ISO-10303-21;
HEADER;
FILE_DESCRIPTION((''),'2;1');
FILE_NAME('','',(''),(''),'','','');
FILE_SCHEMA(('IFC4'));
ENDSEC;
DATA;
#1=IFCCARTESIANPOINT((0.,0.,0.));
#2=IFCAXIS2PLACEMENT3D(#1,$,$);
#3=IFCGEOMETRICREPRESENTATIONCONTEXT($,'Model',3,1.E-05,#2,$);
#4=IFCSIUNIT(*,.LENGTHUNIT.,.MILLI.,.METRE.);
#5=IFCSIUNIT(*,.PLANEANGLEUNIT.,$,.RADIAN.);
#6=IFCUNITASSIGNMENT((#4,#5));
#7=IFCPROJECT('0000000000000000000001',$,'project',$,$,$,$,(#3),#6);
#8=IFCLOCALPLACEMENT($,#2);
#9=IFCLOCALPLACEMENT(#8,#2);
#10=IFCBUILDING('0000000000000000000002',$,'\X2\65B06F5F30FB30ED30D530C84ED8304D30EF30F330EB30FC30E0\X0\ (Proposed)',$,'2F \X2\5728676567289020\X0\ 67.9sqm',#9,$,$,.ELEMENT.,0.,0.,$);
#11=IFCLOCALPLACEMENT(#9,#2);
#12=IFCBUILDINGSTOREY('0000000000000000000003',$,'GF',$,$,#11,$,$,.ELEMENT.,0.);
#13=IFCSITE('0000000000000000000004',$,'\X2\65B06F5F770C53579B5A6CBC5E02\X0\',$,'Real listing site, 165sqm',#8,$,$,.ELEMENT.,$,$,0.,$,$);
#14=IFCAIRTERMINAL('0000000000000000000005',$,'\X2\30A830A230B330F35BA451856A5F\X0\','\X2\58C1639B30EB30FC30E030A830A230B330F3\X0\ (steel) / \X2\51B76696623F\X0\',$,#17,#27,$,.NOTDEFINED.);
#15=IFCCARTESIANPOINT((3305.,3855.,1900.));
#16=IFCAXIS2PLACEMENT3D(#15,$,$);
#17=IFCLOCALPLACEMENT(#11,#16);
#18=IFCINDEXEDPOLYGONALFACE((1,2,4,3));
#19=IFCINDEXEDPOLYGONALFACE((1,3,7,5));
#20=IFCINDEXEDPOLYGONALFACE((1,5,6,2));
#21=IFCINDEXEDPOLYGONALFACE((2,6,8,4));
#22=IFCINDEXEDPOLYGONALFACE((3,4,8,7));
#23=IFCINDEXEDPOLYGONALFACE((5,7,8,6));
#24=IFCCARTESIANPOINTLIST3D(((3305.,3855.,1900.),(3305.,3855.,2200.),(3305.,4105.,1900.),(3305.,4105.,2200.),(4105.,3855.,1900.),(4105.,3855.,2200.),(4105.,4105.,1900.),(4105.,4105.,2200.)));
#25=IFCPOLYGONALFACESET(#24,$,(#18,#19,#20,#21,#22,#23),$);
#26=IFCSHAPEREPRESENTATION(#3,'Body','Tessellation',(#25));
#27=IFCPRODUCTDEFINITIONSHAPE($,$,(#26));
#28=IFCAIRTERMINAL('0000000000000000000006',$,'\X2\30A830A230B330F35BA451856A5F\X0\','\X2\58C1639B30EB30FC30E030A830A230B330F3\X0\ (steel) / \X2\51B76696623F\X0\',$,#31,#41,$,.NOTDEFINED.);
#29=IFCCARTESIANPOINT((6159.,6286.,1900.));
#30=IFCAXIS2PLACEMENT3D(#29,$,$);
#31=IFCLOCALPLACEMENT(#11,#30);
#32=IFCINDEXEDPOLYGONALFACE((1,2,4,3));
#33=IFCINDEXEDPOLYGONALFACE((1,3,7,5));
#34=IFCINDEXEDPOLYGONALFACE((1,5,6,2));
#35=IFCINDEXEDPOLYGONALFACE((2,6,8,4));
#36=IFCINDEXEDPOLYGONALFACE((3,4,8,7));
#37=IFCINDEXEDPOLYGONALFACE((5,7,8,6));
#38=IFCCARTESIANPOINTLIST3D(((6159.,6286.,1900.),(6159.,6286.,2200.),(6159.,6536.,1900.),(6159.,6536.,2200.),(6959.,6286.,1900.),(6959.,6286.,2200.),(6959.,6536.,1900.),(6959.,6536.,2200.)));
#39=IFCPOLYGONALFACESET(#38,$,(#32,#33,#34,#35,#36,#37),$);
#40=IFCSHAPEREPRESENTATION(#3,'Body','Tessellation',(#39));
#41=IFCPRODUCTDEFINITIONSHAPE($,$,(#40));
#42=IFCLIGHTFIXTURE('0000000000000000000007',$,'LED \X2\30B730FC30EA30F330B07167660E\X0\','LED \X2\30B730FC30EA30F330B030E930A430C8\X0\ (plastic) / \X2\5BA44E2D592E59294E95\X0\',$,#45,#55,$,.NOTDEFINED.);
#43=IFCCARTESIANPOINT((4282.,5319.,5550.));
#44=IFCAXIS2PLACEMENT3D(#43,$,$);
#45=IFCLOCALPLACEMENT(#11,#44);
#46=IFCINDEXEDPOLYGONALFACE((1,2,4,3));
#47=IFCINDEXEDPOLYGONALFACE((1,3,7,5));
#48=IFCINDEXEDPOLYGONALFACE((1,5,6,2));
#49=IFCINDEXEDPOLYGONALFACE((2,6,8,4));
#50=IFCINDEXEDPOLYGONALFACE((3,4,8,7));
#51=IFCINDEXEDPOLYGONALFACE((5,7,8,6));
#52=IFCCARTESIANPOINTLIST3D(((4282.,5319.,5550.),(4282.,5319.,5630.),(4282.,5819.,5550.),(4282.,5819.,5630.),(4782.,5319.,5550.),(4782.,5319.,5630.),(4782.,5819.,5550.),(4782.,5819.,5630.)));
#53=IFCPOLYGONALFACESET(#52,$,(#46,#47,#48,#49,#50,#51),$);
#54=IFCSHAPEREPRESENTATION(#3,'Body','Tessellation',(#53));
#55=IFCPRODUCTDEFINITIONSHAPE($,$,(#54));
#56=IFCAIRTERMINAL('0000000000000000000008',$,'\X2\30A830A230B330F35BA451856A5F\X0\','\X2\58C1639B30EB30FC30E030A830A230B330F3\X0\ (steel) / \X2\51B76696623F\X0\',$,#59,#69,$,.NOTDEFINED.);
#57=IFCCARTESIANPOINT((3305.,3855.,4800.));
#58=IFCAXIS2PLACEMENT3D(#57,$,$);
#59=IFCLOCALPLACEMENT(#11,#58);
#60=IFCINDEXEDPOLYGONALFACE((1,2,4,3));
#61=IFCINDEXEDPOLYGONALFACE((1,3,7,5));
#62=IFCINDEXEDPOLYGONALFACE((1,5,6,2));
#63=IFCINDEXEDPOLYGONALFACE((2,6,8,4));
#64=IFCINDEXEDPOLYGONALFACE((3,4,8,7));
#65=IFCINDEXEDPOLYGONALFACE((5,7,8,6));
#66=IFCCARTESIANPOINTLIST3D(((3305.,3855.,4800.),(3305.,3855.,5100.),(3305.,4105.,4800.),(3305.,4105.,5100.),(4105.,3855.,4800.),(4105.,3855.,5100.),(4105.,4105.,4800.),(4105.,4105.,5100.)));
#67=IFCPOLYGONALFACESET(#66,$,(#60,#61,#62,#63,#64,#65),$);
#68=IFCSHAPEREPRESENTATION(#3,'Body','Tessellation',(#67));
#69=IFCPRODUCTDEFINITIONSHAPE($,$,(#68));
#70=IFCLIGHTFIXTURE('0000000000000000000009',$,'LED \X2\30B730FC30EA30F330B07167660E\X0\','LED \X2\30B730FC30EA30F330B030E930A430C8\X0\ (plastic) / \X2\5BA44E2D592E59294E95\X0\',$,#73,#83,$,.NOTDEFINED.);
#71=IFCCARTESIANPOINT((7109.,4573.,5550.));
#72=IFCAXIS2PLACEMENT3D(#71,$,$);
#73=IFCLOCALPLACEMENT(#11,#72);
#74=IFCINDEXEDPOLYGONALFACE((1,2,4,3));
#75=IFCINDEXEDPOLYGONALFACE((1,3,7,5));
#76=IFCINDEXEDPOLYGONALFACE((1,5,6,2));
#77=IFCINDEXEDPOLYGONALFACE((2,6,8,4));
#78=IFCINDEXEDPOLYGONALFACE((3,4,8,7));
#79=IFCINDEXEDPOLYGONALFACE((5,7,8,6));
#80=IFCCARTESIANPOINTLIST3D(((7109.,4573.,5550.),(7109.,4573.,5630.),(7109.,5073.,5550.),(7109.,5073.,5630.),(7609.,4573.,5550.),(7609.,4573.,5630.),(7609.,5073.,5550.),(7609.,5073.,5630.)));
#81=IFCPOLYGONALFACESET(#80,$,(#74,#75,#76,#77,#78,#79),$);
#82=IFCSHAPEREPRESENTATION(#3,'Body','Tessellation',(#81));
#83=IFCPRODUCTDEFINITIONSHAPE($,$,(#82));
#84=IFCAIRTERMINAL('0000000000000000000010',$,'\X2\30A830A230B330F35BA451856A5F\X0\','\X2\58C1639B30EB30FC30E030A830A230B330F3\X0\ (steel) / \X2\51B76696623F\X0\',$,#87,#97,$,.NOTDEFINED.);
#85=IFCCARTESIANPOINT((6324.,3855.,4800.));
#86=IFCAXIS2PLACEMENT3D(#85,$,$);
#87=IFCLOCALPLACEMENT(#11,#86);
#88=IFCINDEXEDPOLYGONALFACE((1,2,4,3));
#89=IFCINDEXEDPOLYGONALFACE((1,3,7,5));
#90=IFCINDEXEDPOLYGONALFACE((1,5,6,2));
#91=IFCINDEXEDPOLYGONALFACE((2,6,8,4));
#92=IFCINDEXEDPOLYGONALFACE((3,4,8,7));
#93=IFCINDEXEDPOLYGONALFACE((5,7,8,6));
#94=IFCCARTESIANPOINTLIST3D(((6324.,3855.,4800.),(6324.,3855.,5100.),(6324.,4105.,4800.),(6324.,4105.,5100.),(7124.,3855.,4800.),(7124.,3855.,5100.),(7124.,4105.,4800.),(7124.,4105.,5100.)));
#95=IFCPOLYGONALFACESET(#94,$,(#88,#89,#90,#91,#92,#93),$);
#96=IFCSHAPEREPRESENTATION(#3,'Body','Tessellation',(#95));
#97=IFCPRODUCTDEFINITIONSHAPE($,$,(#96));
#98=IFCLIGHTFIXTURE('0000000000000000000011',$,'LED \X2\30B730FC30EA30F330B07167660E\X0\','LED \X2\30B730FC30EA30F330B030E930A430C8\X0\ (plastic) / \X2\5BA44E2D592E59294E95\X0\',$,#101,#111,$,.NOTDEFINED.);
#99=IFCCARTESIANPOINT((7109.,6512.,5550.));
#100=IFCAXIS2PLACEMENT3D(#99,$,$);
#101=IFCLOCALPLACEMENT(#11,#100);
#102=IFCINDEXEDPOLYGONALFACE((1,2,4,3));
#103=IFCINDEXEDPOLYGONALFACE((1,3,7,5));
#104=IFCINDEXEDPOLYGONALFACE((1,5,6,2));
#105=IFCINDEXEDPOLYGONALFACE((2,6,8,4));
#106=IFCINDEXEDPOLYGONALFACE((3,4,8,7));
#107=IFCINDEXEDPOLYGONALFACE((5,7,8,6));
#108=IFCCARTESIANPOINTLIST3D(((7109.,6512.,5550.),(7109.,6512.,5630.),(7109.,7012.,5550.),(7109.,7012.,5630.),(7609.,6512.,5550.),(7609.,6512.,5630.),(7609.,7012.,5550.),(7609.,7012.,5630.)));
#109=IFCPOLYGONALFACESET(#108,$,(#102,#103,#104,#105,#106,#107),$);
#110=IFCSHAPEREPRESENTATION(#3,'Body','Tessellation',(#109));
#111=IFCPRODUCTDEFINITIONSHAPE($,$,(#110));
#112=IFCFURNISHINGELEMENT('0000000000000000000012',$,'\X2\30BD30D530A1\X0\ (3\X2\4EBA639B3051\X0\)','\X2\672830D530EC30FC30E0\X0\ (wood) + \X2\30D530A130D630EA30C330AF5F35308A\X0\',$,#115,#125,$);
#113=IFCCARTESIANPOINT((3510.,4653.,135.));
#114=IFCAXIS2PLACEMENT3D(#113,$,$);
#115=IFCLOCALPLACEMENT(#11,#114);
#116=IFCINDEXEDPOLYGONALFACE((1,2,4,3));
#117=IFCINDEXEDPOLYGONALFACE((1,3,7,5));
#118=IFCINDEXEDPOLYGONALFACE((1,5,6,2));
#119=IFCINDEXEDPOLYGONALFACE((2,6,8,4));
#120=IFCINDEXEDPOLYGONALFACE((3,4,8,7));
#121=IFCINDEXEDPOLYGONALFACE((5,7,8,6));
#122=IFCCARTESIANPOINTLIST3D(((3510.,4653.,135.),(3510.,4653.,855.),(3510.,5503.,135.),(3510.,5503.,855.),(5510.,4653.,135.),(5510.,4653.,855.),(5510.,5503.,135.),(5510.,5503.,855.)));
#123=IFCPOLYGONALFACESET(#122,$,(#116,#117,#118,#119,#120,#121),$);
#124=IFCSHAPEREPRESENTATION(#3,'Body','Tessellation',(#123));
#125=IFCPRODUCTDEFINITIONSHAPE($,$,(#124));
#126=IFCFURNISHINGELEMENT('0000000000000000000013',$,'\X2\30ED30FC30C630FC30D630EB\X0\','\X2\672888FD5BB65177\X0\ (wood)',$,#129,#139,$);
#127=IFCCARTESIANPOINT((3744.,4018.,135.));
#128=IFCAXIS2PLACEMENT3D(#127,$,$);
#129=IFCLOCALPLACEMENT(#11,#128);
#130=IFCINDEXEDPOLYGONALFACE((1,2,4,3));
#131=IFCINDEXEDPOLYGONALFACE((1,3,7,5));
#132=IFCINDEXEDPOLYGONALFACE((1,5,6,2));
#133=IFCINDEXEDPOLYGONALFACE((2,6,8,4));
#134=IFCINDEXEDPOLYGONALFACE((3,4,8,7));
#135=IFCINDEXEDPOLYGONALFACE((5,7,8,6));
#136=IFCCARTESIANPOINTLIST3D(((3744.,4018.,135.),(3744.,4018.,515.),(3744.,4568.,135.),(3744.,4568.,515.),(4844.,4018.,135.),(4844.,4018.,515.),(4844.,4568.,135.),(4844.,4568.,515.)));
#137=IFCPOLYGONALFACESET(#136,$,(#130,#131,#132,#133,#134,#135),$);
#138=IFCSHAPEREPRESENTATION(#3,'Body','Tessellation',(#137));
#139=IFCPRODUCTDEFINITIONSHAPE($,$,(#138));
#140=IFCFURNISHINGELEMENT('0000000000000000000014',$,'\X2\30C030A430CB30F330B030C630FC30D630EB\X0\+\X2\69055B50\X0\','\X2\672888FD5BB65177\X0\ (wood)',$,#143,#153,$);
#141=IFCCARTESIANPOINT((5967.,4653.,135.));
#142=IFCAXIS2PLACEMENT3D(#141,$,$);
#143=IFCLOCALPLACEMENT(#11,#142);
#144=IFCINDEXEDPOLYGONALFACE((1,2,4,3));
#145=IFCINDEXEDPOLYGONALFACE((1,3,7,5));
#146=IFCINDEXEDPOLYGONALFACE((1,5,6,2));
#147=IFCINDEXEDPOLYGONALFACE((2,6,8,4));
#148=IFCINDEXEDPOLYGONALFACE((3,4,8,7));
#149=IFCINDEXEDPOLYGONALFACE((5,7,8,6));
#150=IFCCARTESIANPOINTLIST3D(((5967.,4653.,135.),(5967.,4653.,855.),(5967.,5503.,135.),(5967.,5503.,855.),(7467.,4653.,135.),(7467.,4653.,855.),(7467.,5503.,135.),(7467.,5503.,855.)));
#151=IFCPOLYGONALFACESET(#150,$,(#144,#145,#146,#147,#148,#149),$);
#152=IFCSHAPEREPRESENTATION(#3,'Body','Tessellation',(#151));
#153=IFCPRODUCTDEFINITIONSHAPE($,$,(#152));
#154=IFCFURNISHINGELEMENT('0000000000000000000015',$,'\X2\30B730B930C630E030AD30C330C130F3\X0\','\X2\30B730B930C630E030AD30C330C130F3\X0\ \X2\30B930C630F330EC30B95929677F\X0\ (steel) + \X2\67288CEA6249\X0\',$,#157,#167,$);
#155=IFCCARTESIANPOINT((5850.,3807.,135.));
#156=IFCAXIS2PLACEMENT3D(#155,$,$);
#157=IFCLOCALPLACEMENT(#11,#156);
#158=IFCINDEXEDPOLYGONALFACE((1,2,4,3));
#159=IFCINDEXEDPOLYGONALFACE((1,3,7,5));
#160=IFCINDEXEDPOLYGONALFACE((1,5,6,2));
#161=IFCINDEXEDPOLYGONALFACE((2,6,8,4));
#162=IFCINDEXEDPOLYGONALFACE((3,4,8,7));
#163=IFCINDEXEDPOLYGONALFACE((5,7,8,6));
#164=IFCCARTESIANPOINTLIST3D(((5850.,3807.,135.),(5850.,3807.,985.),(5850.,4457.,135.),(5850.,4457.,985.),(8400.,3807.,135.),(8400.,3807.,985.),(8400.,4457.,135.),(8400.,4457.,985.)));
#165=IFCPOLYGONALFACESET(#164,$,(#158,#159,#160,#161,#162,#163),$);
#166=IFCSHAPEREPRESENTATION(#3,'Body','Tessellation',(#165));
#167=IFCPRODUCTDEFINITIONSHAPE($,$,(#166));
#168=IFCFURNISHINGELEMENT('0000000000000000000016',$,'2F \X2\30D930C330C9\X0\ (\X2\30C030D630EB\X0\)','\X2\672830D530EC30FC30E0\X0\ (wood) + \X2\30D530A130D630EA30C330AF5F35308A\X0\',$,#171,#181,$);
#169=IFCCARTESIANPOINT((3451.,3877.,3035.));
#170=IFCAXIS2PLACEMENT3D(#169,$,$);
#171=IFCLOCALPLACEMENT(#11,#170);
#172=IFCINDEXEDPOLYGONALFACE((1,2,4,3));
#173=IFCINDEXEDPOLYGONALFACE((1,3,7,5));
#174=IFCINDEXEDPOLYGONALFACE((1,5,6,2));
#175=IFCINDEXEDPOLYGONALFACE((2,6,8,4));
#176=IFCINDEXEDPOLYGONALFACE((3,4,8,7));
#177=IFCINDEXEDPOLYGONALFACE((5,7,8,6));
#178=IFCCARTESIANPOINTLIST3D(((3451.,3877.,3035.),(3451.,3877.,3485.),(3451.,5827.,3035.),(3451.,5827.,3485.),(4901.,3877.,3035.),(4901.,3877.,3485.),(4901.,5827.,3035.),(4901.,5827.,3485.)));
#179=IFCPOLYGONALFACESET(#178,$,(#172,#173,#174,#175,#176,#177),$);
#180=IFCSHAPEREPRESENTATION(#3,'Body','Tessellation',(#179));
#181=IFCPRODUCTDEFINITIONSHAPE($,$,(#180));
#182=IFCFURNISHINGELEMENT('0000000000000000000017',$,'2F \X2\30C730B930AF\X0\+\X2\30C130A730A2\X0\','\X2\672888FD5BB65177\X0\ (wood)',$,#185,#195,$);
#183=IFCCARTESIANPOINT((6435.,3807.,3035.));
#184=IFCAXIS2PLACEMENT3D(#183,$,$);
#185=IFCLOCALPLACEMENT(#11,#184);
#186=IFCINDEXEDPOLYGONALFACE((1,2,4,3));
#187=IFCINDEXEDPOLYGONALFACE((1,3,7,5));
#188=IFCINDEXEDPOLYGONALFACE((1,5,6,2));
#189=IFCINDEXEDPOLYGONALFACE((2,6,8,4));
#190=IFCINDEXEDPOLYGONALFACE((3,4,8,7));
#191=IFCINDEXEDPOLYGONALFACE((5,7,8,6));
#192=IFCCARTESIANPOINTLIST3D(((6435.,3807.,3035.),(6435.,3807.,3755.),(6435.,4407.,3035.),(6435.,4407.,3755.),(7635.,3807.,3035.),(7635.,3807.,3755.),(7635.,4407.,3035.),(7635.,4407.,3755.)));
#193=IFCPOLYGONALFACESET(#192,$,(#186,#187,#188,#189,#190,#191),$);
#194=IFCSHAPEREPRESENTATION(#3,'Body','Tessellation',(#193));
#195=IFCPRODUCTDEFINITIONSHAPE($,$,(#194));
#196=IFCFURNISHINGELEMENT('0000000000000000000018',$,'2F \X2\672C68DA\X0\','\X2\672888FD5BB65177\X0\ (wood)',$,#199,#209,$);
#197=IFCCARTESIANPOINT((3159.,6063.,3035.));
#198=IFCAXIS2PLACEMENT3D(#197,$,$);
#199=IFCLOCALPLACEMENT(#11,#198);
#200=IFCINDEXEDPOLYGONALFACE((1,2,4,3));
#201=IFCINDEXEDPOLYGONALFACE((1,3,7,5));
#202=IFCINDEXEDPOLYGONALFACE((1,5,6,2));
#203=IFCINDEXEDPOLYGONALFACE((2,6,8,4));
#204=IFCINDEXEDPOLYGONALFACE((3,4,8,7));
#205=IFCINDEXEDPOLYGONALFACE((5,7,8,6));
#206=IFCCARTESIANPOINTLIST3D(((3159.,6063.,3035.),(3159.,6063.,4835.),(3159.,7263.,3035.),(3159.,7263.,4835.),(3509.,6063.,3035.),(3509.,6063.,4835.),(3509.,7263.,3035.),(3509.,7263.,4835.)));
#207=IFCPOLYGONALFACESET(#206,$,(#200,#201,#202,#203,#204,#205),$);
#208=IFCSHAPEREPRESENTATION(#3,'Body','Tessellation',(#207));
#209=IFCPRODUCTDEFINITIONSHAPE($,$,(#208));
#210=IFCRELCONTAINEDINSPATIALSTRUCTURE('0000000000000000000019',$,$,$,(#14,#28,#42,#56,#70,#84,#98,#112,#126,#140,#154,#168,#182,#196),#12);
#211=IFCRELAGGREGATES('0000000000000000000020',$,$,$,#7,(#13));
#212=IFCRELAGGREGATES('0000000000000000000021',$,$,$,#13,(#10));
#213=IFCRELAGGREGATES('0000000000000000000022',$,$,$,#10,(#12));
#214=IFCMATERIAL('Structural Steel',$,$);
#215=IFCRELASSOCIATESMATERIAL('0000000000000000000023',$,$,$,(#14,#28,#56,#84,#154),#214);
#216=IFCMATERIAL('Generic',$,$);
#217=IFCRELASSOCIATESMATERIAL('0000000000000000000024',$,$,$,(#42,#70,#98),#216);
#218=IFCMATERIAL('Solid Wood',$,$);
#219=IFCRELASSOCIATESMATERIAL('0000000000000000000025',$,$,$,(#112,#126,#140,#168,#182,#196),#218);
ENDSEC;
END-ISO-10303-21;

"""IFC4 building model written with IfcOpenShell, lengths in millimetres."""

from ifc_helpers import new_model, si_unit, frame, frame_2d, origin, place, context, project, spatial, rectangle, extrude, material, element, save


model = new_model("IFC4")

# Units and contexts
model_context = context("Model", 3, precision=1e-05, world=origin())
ifc_project = project(units=[si_unit("LENGTHUNIT", "METRE", prefix="MILLI"), si_unit("PLANEANGLEUNIT", "RADIAN")], contexts=[model_context])

# Site, building, storey
site_placement = place(None, origin())
site = spatial("IfcSite", under=ifc_project, at=site_placement, Name="新潟県南魚沼市", ObjectType="Real listing site, 165sqm", CompositionType="ELEMENT", RefElevation=0.0)
building_placement = place(site_placement, origin())
building = spatial("IfcBuilding", under=site, at=building_placement, Name="新潟・ロフト付きワンルーム (Proposed)", ObjectType="2F 在来木造 67.9sqm", CompositionType="ELEMENT", ElevationOfRefHeight=0.0, ElevationOfTerrain=0.0)
storey_placement = place(building_placement, origin())
storey = spatial("IfcBuildingStorey", under=building, at=storey_placement, Name="GF", CompositionType="ELEMENT", Elevation=0.0)

# Shared definitions
ifc_material_1 = material(Name="Solid Wood")

# Shared definitions
ifc_material_2 = material(Name="Structural Steel")

# Shared definitions
ifc_material_3 = material(Name="Generic")

# Air terminals
air_terminal_1_placement = place(storey_placement, frame((3305.0, 3855.0, 1900.0)))
element("IfcAirTerminal", 1, at=air_terminal_1_placement, inside=storey, material=ifc_material_2, Name="エアコン室内機", Description="壁掛ルームエアコン (steel) / 冷暖房", PredefinedType="NOTDEFINED", context=model_context, shape_type="SweptSolid", body=[
    extrude(rectangle(XDim=800.0, YDim=250.0, at=frame_2d((400.0, 125.0))), frame((3305.0, 3855.0, 1900.0)), (0.0, 0.0, 1.0), 300.0),
])
air_terminal_2_placement = place(storey_placement, frame((6159.0, 6286.0, 1900.0)))
element("IfcAirTerminal", 2, at=air_terminal_2_placement, inside=storey, material=ifc_material_2, Name="エアコン室内機", Description="壁掛ルームエアコン (steel) / 冷暖房", PredefinedType="NOTDEFINED", context=model_context, shape_type="SweptSolid", body=[
    extrude(rectangle(XDim=800.0, YDim=250.0, at=frame_2d((400.0, 125.0))), frame((6159.0, 6286.0, 1900.0)), (0.0, 0.0, 1.0), 300.0),
])

# Light fixture
light_fixture_1_placement = place(storey_placement, frame((4282.0, 5319.0, 5550.0)))
element("IfcLightFixture", 3, at=light_fixture_1_placement, inside=storey, material=ifc_material_3, Name="LED シーリング照明", Description="LED シーリングライト (plastic) / 室中央天井", PredefinedType="NOTDEFINED", context=model_context, shape_type="SweptSolid", body=[
    extrude(rectangle(XDim=500.0, YDim=500.0, at=frame_2d((250.0, 250.0))), frame((4282.0, 5319.0, 5550.0)), (0.0, 0.0, 1.0), 80.0),
])

# Air terminal
air_terminal_3_placement = place(storey_placement, frame((3305.0, 3855.0, 4800.0)))
element("IfcAirTerminal", 4, at=air_terminal_3_placement, inside=storey, material=ifc_material_2, Name="エアコン室内機", Description="壁掛ルームエアコン (steel) / 冷暖房", PredefinedType="NOTDEFINED", context=model_context, shape_type="SweptSolid", body=[
    extrude(rectangle(XDim=800.0, YDim=250.0, at=frame_2d((400.0, 125.0))), frame((3305.0, 3855.0, 4800.0)), (0.0, 0.0, 1.0), 300.0),
])

# Light fixture
light_fixture_2_placement = place(storey_placement, frame((7109.0, 4573.0, 5550.0)))
element("IfcLightFixture", 5, at=light_fixture_2_placement, inside=storey, material=ifc_material_3, Name="LED シーリング照明", Description="LED シーリングライト (plastic) / 室中央天井", PredefinedType="NOTDEFINED", context=model_context, shape_type="SweptSolid", body=[
    extrude(rectangle(XDim=500.0, YDim=500.0, at=frame_2d((250.0, 250.0))), frame((7109.0, 4573.0, 5550.0)), (0.0, 0.0, 1.0), 80.0),
])

# Air terminal
air_terminal_4_placement = place(storey_placement, frame((6324.0, 3855.0, 4800.0)))
element("IfcAirTerminal", 6, at=air_terminal_4_placement, inside=storey, material=ifc_material_2, Name="エアコン室内機", Description="壁掛ルームエアコン (steel) / 冷暖房", PredefinedType="NOTDEFINED", context=model_context, shape_type="SweptSolid", body=[
    extrude(rectangle(XDim=800.0, YDim=250.0, at=frame_2d((400.0, 125.0))), frame((6324.0, 3855.0, 4800.0)), (0.0, 0.0, 1.0), 300.0),
])

# Light fixture
light_fixture_3_placement = place(storey_placement, frame((7109.0, 6512.0, 5550.0)))
element("IfcLightFixture", 7, at=light_fixture_3_placement, inside=storey, material=ifc_material_3, Name="LED シーリング照明", Description="LED シーリングライト (plastic) / 室中央天井", PredefinedType="NOTDEFINED", context=model_context, shape_type="SweptSolid", body=[
    extrude(rectangle(XDim=500.0, YDim=500.0, at=frame_2d((250.0, 250.0))), frame((7109.0, 6512.0, 5550.0)), (0.0, 0.0, 1.0), 80.0),
])

# Furnishing elements
furnishing_1_placement = place(storey_placement, frame((3510.0, 4653.0, 135.0)))
element("IfcFurnishingElement", 8, at=furnishing_1_placement, inside=storey, material=ifc_material_1, Name="ソファ (3人掛け)", Description="木フレーム (wood) + ファブリック張り", context=model_context, shape_type="SweptSolid", body=[
    extrude(rectangle(XDim=2000.0, YDim=850.0, at=frame_2d((1000.0, 425.0))), frame((3510.0, 4653.0, 135.0)), (0.0, 0.0, 1.0), 720.0),
])
furnishing_2_placement = place(storey_placement, frame((3744.0, 4018.0, 135.0)))
element("IfcFurnishingElement", 9, at=furnishing_2_placement, inside=storey, material=ifc_material_1, Name="ローテーブル", Description="木製家具 (wood)", context=model_context, shape_type="SweptSolid", body=[
    extrude(rectangle(XDim=1100.0, YDim=550.0, at=frame_2d((550.0, 275.0))), frame((3744.0, 4018.0, 135.0)), (0.0, 0.0, 1.0), 380.0),
])
furnishing_3_placement = place(storey_placement, frame((5967.0, 4653.0, 135.0)))
element("IfcFurnishingElement", 10, at=furnishing_3_placement, inside=storey, material=ifc_material_1, Name="ダイニングテーブル+椅子", Description="木製家具 (wood)", context=model_context, shape_type="SweptSolid", body=[
    extrude(rectangle(XDim=1500.0, YDim=850.0, at=frame_2d((750.0, 425.0))), frame((5967.0, 4653.0, 135.0)), (0.0, 0.0, 1.0), 720.0),
])
furnishing_4_placement = place(storey_placement, frame((5850.0, 3807.0, 135.0)))
element("IfcFurnishingElement", 11, at=furnishing_4_placement, inside=storey, material=ifc_material_2, Name="システムキッチン", Description="システムキッチン ステンレス天板 (steel) + 木質扉", context=model_context, shape_type="SweptSolid", body=[
    extrude(rectangle(XDim=2550.0, YDim=650.0, at=frame_2d((1275.0, 325.0))), frame((5850.0, 3807.0, 135.0)), (0.0, 0.0, 1.0), 850.0),
])
furnishing_5_placement = place(storey_placement, frame((3451.0, 3877.0, 3035.0)))
element("IfcFurnishingElement", 12, at=furnishing_5_placement, inside=storey, material=ifc_material_1, Name="2F ベッド (ダブル)", Description="木フレーム (wood) + ファブリック張り", context=model_context, shape_type="SweptSolid", body=[
    extrude(rectangle(XDim=1450.0, YDim=1950.0, at=frame_2d((725.0, 975.0))), frame((3451.0, 3877.0, 3035.0)), (0.0, 0.0, 1.0), 450.0),
])
furnishing_6_placement = place(storey_placement, frame((6435.0, 3807.0, 3035.0)))
element("IfcFurnishingElement", 13, at=furnishing_6_placement, inside=storey, material=ifc_material_1, Name="2F デスク+チェア", Description="木製家具 (wood)", context=model_context, shape_type="SweptSolid", body=[
    extrude(rectangle(XDim=1200.0, YDim=600.0, at=frame_2d((600.0, 300.0))), frame((6435.0, 3807.0, 3035.0)), (0.0, 0.0, 1.0), 720.0),
])
furnishing_7_placement = place(storey_placement, frame((3159.0, 6063.0, 3035.0)))
element("IfcFurnishingElement", 14, at=furnishing_7_placement, inside=storey, material=ifc_material_1, Name="2F 本棚", Description="木製家具 (wood)", context=model_context, shape_type="SweptSolid", body=[
    extrude(rectangle(XDim=350.0, YDim=1200.0, at=frame_2d((175.0, 600.0))), frame((3159.0, 6063.0, 3035.0)), (0.0, 0.0, 1.0), 1800.0),
])

save(model, "model.ifc")
